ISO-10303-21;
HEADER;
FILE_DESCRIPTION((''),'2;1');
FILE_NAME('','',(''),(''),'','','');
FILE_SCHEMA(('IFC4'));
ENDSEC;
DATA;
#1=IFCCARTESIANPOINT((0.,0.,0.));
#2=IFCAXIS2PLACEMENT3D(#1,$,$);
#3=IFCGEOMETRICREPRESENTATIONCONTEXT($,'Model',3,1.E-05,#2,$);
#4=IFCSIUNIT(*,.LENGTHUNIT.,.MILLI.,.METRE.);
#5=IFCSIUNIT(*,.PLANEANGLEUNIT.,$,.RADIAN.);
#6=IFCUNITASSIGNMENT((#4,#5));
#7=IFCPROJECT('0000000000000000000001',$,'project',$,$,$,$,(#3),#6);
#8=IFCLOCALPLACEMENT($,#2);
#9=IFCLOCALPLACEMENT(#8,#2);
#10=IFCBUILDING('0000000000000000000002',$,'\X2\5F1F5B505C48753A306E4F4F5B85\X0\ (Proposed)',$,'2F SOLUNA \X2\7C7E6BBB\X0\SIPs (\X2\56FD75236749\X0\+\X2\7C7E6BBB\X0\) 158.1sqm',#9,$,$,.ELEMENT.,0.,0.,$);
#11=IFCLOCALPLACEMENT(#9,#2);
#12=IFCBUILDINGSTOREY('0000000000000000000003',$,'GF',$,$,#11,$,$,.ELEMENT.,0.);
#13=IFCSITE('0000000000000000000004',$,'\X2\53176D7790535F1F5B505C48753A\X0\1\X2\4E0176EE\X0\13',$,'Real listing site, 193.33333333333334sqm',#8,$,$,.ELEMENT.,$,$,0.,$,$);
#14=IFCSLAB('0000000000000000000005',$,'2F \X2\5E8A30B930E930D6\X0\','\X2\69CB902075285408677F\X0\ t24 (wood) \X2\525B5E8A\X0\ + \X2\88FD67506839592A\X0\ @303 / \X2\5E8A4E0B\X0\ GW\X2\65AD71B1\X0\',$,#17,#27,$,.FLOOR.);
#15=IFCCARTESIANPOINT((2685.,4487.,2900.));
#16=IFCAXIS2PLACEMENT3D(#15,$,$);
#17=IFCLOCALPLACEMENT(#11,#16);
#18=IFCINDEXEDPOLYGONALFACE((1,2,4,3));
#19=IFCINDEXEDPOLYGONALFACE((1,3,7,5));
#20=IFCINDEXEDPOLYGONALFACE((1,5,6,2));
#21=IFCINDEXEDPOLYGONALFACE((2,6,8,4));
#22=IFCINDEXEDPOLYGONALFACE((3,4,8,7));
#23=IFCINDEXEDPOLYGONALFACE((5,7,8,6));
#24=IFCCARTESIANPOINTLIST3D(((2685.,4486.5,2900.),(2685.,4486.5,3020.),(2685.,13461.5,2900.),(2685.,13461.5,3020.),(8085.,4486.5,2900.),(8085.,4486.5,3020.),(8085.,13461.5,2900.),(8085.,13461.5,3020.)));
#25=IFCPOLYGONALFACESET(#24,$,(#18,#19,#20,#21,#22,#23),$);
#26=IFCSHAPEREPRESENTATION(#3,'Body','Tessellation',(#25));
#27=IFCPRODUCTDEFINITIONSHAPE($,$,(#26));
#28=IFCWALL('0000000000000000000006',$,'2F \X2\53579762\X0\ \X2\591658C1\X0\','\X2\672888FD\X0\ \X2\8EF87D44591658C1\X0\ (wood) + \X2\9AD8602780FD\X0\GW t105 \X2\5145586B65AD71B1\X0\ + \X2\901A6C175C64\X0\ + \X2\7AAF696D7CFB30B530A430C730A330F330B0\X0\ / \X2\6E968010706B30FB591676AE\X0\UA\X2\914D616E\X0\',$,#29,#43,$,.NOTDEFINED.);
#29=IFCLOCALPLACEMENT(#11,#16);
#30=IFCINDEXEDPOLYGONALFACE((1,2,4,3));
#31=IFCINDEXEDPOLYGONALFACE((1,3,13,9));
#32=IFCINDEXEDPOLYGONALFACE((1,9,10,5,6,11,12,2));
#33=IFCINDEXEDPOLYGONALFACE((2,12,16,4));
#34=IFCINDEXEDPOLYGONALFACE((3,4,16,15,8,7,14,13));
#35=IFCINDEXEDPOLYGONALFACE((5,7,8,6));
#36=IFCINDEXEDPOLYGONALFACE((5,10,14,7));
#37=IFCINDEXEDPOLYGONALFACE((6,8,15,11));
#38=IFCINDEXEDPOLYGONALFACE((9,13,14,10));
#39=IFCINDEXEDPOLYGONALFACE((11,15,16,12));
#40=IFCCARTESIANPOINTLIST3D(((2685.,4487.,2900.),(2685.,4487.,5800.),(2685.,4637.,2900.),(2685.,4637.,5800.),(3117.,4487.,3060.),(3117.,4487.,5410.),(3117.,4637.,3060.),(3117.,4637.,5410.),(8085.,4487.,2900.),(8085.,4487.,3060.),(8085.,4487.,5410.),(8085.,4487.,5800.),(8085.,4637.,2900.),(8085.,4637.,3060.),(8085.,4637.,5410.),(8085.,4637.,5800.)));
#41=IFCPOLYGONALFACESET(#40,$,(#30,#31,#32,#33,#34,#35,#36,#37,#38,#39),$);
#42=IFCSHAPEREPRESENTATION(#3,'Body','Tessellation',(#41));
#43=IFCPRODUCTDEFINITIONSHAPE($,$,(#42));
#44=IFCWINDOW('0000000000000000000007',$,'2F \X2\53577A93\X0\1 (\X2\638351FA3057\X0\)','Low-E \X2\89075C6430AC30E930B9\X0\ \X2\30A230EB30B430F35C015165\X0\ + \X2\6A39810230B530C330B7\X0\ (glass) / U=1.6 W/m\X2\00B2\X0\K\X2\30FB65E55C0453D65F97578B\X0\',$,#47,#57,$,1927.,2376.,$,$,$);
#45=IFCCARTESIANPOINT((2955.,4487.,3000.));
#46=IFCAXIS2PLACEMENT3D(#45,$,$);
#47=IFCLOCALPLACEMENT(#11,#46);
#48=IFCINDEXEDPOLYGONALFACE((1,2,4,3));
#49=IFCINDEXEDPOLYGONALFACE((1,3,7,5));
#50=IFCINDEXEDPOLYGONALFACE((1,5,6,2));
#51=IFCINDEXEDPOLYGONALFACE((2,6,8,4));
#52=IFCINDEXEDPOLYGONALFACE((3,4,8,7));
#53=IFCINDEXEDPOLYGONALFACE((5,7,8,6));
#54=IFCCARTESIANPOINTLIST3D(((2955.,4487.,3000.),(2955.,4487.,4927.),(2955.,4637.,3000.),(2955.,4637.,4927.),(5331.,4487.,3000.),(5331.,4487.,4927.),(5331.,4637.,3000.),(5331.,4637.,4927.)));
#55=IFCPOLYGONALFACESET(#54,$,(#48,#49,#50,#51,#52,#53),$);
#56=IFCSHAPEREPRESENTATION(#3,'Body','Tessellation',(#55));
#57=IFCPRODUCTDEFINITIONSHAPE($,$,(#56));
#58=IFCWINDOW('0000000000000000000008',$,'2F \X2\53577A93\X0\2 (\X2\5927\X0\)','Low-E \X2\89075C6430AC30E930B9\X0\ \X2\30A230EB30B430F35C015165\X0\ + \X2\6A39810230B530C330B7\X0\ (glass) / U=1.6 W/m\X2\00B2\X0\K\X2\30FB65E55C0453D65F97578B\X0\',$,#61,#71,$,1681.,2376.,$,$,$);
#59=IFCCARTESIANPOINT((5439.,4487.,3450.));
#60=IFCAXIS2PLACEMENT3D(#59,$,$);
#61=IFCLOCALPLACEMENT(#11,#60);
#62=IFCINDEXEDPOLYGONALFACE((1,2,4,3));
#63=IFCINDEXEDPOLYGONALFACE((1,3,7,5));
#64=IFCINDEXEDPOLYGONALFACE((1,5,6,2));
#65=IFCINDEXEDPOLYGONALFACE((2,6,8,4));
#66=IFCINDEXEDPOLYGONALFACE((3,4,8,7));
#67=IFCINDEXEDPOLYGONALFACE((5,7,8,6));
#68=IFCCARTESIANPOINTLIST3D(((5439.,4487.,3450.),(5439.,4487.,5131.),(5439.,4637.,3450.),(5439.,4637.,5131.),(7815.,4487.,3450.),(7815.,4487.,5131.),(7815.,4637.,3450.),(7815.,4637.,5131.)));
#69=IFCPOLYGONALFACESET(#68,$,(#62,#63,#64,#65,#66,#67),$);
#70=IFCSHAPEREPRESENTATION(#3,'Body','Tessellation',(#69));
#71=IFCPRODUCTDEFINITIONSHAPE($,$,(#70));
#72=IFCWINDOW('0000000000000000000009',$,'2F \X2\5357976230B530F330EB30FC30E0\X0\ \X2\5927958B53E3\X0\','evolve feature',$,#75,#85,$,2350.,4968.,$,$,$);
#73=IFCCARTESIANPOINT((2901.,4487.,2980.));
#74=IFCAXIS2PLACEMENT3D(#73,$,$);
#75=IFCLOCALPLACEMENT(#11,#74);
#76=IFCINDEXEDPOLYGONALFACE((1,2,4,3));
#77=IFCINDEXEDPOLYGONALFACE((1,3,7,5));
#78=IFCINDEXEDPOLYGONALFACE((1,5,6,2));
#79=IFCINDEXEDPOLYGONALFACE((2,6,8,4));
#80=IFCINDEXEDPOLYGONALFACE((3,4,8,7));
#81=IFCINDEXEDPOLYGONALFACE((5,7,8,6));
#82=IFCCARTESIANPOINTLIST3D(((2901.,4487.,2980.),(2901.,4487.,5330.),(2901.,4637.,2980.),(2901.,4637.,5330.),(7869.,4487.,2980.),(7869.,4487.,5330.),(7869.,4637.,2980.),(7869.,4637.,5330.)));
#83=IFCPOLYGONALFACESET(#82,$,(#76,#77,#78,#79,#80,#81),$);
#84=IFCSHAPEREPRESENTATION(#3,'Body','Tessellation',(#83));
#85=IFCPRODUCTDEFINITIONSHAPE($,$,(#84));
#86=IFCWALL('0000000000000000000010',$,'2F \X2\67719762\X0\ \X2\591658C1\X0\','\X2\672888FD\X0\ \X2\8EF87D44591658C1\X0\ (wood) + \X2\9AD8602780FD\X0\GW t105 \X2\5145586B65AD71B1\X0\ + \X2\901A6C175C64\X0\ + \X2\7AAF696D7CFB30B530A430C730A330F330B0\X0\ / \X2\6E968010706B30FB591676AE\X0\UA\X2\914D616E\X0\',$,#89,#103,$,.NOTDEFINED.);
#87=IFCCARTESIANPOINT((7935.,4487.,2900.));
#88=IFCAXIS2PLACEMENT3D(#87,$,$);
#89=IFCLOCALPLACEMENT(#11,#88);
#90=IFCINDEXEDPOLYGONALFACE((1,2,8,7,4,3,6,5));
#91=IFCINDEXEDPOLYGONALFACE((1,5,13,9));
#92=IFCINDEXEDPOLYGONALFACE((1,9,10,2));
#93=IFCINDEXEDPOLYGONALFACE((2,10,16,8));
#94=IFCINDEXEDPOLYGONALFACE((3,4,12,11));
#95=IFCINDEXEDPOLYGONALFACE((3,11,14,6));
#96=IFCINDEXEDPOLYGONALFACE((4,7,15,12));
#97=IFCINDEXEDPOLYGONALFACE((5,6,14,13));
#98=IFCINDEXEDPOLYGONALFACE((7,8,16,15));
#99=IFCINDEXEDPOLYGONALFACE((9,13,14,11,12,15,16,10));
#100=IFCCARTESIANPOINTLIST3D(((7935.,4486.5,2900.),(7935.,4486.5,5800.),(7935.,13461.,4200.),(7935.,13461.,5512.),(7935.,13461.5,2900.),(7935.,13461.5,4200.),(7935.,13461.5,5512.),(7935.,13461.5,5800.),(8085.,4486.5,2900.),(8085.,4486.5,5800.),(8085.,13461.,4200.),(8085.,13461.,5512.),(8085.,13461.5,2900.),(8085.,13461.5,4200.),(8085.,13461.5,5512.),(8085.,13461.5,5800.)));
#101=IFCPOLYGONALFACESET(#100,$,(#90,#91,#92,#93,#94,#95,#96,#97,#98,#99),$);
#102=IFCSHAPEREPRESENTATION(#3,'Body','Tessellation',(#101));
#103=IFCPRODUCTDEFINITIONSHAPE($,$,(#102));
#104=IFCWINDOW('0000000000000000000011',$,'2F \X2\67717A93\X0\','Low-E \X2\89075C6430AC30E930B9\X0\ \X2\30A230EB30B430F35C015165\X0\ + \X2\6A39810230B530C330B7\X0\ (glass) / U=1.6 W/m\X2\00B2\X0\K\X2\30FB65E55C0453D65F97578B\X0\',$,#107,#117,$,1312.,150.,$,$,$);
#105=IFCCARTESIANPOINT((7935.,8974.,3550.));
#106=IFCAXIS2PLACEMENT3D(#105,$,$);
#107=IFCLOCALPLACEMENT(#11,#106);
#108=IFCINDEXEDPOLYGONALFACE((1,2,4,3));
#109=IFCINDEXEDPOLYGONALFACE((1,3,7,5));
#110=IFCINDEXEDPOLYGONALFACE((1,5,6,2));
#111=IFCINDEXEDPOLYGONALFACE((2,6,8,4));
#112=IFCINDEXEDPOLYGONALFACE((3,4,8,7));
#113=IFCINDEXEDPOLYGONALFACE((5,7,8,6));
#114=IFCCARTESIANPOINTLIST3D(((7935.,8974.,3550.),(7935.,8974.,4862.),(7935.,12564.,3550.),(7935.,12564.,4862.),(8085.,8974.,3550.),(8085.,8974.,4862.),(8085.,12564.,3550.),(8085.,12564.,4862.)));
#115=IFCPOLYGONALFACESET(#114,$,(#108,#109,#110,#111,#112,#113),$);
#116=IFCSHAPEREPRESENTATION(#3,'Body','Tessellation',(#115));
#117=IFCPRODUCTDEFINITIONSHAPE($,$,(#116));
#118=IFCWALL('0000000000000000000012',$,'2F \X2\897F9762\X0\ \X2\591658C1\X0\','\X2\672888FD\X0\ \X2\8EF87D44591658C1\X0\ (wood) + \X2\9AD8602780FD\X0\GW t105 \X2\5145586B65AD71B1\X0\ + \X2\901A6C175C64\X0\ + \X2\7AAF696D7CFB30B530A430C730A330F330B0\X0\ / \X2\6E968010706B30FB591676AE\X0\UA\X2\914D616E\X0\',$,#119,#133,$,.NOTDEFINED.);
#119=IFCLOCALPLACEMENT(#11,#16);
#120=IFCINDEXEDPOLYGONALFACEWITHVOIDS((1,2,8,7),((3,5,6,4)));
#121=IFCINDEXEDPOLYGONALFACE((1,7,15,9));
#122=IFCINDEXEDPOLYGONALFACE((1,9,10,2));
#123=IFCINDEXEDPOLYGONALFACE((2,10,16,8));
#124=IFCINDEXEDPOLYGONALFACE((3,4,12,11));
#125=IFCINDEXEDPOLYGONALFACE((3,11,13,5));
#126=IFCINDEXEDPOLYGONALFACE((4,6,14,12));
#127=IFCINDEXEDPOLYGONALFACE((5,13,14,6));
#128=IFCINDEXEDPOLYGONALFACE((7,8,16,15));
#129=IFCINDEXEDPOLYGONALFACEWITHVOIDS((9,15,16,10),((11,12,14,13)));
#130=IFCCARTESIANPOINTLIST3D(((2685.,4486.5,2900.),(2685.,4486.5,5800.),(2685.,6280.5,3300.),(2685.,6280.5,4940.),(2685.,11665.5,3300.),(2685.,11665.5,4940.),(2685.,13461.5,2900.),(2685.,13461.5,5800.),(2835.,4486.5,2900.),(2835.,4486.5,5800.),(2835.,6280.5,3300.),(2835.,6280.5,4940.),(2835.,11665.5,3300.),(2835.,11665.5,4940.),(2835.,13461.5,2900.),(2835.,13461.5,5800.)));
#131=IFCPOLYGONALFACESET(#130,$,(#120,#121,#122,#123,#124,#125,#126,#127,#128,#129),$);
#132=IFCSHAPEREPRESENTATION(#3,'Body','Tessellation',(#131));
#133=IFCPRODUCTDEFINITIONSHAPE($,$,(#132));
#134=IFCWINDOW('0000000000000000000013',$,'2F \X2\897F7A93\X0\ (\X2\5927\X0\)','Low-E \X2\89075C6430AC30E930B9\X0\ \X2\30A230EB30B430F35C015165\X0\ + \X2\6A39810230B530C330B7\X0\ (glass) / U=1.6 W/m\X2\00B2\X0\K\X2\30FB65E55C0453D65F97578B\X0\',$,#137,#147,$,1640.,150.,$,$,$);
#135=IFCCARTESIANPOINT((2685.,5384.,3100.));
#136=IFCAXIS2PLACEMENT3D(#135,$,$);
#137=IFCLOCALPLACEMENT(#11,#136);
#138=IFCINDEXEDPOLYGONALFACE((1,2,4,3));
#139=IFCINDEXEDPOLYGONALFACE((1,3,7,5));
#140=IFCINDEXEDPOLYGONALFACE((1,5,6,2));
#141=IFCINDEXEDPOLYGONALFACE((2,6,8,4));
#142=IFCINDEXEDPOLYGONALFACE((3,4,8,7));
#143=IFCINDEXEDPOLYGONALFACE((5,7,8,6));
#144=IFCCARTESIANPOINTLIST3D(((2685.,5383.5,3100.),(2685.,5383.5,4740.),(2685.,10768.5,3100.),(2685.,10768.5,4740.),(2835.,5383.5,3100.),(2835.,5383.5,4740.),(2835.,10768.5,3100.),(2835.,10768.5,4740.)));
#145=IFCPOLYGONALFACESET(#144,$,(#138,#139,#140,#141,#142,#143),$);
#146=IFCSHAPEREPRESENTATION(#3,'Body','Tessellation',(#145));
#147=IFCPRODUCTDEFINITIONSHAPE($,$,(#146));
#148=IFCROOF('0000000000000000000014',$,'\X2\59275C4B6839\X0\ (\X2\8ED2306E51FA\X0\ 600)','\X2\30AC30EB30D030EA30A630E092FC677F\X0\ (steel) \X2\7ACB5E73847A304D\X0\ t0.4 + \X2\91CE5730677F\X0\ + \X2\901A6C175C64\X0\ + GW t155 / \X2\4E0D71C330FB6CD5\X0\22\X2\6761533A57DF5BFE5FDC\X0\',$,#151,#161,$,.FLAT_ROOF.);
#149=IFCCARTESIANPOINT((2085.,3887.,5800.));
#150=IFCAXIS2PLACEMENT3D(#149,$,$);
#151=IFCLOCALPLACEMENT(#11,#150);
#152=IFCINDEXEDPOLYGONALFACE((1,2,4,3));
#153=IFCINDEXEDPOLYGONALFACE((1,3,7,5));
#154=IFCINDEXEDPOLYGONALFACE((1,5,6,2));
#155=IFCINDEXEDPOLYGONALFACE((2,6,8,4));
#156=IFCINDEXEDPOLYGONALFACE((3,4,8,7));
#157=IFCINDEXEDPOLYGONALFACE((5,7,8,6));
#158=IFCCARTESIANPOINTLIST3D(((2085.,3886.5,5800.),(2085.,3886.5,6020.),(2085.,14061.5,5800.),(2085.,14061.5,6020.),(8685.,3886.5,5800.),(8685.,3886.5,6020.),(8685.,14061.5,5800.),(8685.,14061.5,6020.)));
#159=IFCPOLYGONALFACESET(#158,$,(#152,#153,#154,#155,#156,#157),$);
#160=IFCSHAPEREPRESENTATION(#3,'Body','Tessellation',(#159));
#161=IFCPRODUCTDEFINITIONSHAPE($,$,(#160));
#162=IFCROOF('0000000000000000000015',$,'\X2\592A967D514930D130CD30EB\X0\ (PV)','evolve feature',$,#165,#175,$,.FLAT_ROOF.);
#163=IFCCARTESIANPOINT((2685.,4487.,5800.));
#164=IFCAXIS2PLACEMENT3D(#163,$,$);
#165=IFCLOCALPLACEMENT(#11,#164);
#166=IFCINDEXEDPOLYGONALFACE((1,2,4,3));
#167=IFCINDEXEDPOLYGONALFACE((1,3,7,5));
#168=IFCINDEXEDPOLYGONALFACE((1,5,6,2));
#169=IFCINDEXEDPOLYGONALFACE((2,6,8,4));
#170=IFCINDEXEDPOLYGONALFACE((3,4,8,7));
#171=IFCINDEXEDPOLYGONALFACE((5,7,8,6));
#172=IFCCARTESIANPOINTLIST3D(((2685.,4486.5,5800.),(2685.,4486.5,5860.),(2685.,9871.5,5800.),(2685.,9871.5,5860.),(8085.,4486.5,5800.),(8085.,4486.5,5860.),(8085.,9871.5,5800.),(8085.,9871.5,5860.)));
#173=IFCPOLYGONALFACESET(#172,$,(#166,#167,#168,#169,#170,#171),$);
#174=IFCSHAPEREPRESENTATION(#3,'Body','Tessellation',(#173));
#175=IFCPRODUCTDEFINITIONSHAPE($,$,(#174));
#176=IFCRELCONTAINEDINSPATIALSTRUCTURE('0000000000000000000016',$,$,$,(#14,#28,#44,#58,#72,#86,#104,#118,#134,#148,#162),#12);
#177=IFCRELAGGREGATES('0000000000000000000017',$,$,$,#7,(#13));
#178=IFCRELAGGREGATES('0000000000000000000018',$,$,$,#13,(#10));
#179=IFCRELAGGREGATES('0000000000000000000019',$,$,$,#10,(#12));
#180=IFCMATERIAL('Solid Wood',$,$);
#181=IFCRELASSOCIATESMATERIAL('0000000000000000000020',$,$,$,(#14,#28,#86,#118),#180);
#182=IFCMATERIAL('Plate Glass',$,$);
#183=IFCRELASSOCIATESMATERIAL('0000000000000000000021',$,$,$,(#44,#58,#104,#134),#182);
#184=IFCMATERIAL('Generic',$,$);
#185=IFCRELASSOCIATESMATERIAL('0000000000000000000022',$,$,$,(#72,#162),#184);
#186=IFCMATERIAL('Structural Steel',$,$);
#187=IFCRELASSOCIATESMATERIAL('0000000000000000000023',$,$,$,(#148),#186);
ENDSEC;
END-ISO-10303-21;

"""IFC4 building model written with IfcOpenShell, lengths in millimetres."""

from ifc_helpers import new_model, si_unit, frame, frame_2d, origin, place, context, project, spatial, rectangle, extrude, material, element, fill, save


model = new_model("IFC4")

# Units and contexts
model_context = context("Model", 3, precision=1e-05, world=origin())
ifc_project = project(units=[si_unit("LENGTHUNIT", "METRE", prefix="MILLI"), si_unit("PLANEANGLEUNIT", "RADIAN")], contexts=[model_context])

# Site, building, storey
site_placement = place(None, origin())
site = spatial("IfcSite", under=ifc_project, at=site_placement, Name="北海道弟子屈町1丁目13", ObjectType="Real listing site, 193.33333333333334sqm", CompositionType="ELEMENT", RefElevation=0.0)
building_placement = place(site_placement, origin())
building = spatial("IfcBuilding", under=site, at=building_placement, Name="弟子屈町の住宅 (Proposed)", ObjectType="2F SOLUNA 籾殻SIPs (国産杉+籾殻) 158.1sqm", CompositionType="ELEMENT", ElevationOfRefHeight=0.0, ElevationOfTerrain=0.0)
storey_placement = place(building_placement, origin())
storey = spatial("IfcBuildingStorey", under=building, at=storey_placement, Name="GF", CompositionType="ELEMENT", Elevation=0.0)

# Slab
ifc_material_1 = material(Name="Solid Wood")
slab_placement = place(storey_placement, frame((2685.0, 4487.0, 2900.0)))
element("IfcSlab", 1, at=slab_placement, inside=storey, material=ifc_material_1, Name="2F 床スラブ", Description="構造用合板 t24 (wood) 剛床 + 製材根太 @303 / 床下 GW断熱", PredefinedType="FLOOR", context=model_context, shape_type="SweptSolid", body=[
    extrude(rectangle(XDim=5400.0, YDim=8975.0, at=frame_2d((2700.0, 4487.0))), frame((2685.0, 4487.0, 2900.0)), (0.0, 0.0, 1.0), 120.0),
])

# Wall, openings, windows
wall_1_placement = place(storey_placement, frame((2685.0, 4487.0, 2900.0)))
wall_1 = element("IfcWall", 2, at=wall_1_placement, inside=storey, material=ifc_material_1, Name="2F 南面 外壁", Description="木製 軸組外壁 (wood) + 高性能GW t105 充填断熱 + 通気層 + 窯業系サイディング / 準耐火・外皮UA配慮", PredefinedType="NOTDEFINED", context=model_context, shape_type="SweptSolid", body=[
    extrude(rectangle(XDim=5400.0, YDim=150.0, at=frame_2d((2700.0, 75.0))), frame((2685.0, 4487.0, 2900.0)), (0.0, 0.0, 1.0), 2900.0),
])
opening_1_placement = place(storey_placement, frame((2955.0, 4487.0, 3000.0)))
opening_1 = element("IfcOpeningElement", 3, at=opening_1_placement, cuts=wall_1, PredefinedType="NOTDEFINED", context=model_context, shape_type="SweptSolid", body=[
    extrude(rectangle(XDim=2376.0, YDim=150.0, at=frame_2d((1188.0, 75.0))), frame((2955.0, 4487.0, 3000.0)), (0.0, 0.0, 1.0), 1927.0),
])
opening_2_placement = place(storey_placement, frame((5439.0, 4487.0, 3450.0)))
opening_2 = element("IfcOpeningElement", 4, at=opening_2_placement, cuts=wall_1, PredefinedType="NOTDEFINED", context=model_context, shape_type="SweptSolid", body=[
    extrude(rectangle(XDim=2376.0, YDim=150.0, at=frame_2d((1188.0, 75.0))), frame((5439.0, 4487.0, 3450.0)), (0.0, 0.0, 1.0), 1681.0),
])
opening_3_placement = place(storey_placement, frame((2901.0, 4487.0, 2980.0)))
opening_3 = element("IfcOpeningElement", 5, at=opening_3_placement, cuts=wall_1, PredefinedType="NOTDEFINED", context=model_context, shape_type="SweptSolid", body=[
    extrude(rectangle(XDim=4968.0, YDim=150.0, at=frame_2d((2484.0, 75.0))), frame((2901.0, 4487.0, 2980.0)), (0.0, 0.0, 1.0), 2350.0),
])
ifc_material_2 = material(Name="Plate Glass")
window_1_placement = place(storey_placement, frame((2955.0, 4487.0, 3000.0)))
window_1 = element("IfcWindow", 6, at=window_1_placement, inside=storey, material=ifc_material_2, Name="2F 南窓1 (掃出し)", Description="Low-E 複層ガラス アルゴン封入 + 樹脂サッシ (glass) / U=1.6 W/m²K・日射取得型", OverallHeight=1927.0, OverallWidth=2376.0, context=model_context, shape_type="SweptSolid", body=[
    extrude(rectangle(XDim=2376.0, YDim=150.0, at=frame_2d((1188.0, 75.0))), frame((2955.0, 4487.0, 3000.0)), (0.0, 0.0, 1.0), 1927.0),
])
fill(opening_1, window_1)
window_2_placement = place(storey_placement, frame((5439.0, 4487.0, 3450.0)))
window_2 = element("IfcWindow", 7, at=window_2_placement, inside=storey, material=ifc_material_2, Name="2F 南窓2 (大)", Description="Low-E 複層ガラス アルゴン封入 + 樹脂サッシ (glass) / U=1.6 W/m²K・日射取得型", OverallHeight=1681.0, OverallWidth=2376.0, context=model_context, shape_type="SweptSolid", body=[
    extrude(rectangle(XDim=2376.0, YDim=150.0, at=frame_2d((1188.0, 75.0))), frame((5439.0, 4487.0, 3450.0)), (0.0, 0.0, 1.0), 1681.0),
])
fill(opening_2, window_2)
ifc_material_3 = material(Name="Generic")
window_3_placement = place(storey_placement, frame((2901.0, 4487.0, 2980.0)))
window_3 = element("IfcWindow", 8, at=window_3_placement, inside=storey, material=ifc_material_3, Name="2F 南面サンルーム 大開口", Description="evolve feature", OverallHeight=2350.0, OverallWidth=4968.0, context=model_context, shape_type="SweptSolid", body=[
    extrude(rectangle(XDim=4968.0, YDim=150.0, at=frame_2d((2484.0, 75.0))), frame((2901.0, 4487.0, 2980.0)), (0.0, 0.0, 1.0), 2350.0),
])
fill(opening_3, window_3)

# Walls, openings, windows
wall_2_placement = place(storey_placement, frame((7935.0, 4487.0, 2900.0)))
wall_2 = element("IfcWall", 9, at=wall_2_placement, inside=storey, material=ifc_material_1, Name="2F 東面 外壁", Description="木製 軸組外壁 (wood) + 高性能GW t105 充填断熱 + 通気層 + 窯業系サイディング / 準耐火・外皮UA配慮", PredefinedType="NOTDEFINED", context=model_context, shape_type="SweptSolid", body=[
    extrude(rectangle(XDim=150.0, YDim=8975.0, at=frame_2d((75.0, 4487.0))), frame((7935.0, 4487.0, 2900.0)), (0.0, 0.0, 1.0), 2900.0),
])
opening_4_placement = place(storey_placement, frame((7935.0, 8974.0, 3550.0)))
opening_4 = element("IfcOpeningElement", 10, at=opening_4_placement, cuts=wall_2, PredefinedType="NOTDEFINED", context=model_context, shape_type="SweptSolid", body=[
    extrude(rectangle(XDim=150.0, YDim=3590.0, at=frame_2d((75.0, 1795.0))), frame((7935.0, 8974.0, 3550.0)), (0.0, 0.0, 1.0), 1312.0),
])
window_4_placement = place(storey_placement, frame((7935.0, 8974.0, 3550.0)))
window_4 = element("IfcWindow", 11, at=window_4_placement, inside=storey, material=ifc_material_2, Name="2F 東窓", Description="Low-E 複層ガラス アルゴン封入 + 樹脂サッシ (glass) / U=1.6 W/m²K・日射取得型", OverallHeight=1312.0, OverallWidth=150.0, context=model_context, shape_type="SweptSolid", body=[
    extrude(rectangle(XDim=150.0, YDim=3590.0, at=frame_2d((75.0, 1795.0))), frame((7935.0, 8974.0, 3550.0)), (0.0, 0.0, 1.0), 1312.0),
])
fill(opening_4, window_4)
wall_3_placement = place(storey_placement, frame((2685.0, 4487.0, 2900.0)))
wall_3 = element("IfcWall", 12, at=wall_3_placement, inside=storey, material=ifc_material_1, Name="2F 西面 外壁", Description="木製 軸組外壁 (wood) + 高性能GW t105 充填断熱 + 通気層 + 窯業系サイディング / 準耐火・外皮UA配慮", PredefinedType="NOTDEFINED", context=model_context, shape_type="SweptSolid", body=[
    extrude(rectangle(XDim=150.0, YDim=8975.0, at=frame_2d((75.0, 4487.0))), frame((2685.0, 4487.0, 2900.0)), (0.0, 0.0, 1.0), 2900.0),
])
opening_5_placement = place(storey_placement, frame((2685.0, 5384.0, 3100.0)))
opening_5 = element("IfcOpeningElement", 13, at=opening_5_placement, cuts=wall_3, PredefinedType="NOTDEFINED", context=model_context, shape_type="SweptSolid", body=[
    extrude(rectangle(XDim=150.0, YDim=5385.0, at=frame_2d((75.0, 2692.0))), frame((2685.0, 5384.0, 3100.0)), (0.0, 0.0, 1.0), 1640.0),
])
window_5_placement = place(storey_placement, frame((2685.0, 5384.0, 3100.0)))
window_5 = element("IfcWindow", 14, at=window_5_placement, inside=storey, material=ifc_material_2, Name="2F 西窓 (大)", Description="Low-E 複層ガラス アルゴン封入 + 樹脂サッシ (glass) / U=1.6 W/m²K・日射取得型", OverallHeight=1640.0, OverallWidth=150.0, context=model_context, shape_type="SweptSolid", body=[
    extrude(rectangle(XDim=150.0, YDim=5385.0, at=frame_2d((75.0, 2692.0))), frame((2685.0, 5384.0, 3100.0)), (0.0, 0.0, 1.0), 1640.0),
])
fill(opening_5, window_5)

# Roofs
ifc_material_4 = material(Name="Structural Steel")
roof_1_placement = place(storey_placement, frame((2085.0, 3887.0, 5800.0)))
element("IfcRoof", 15, at=roof_1_placement, inside=storey, material=ifc_material_4, Name="大屋根 (軒の出 600)", Description="ガルバリウム鋼板 (steel) 立平葺き t0.4 + 野地板 + 通気層 + GW t155 / 不燃・法22条区域対応", PredefinedType="FLAT_ROOF", context=model_context, shape_type="SweptSolid", body=[
    extrude(rectangle(XDim=6600.0, YDim=10175.0, at=frame_2d((3300.0, 5087.0))), frame((2085.0, 3887.0, 5800.0)), (0.0, 0.0, 1.0), 220.0),
])
roof_2_placement = place(storey_placement, frame((2685.0, 4487.0, 5800.0)))
element("IfcRoof", 16, at=roof_2_placement, inside=storey, material=ifc_material_3, Name="太陽光パネル (PV)", Description="evolve feature", PredefinedType="FLAT_ROOF", context=model_context, shape_type="SweptSolid", body=[
    extrude(rectangle(XDim=5400.0, YDim=5385.0, at=frame_2d((2700.0, 2692.0))), frame((2685.0, 4487.0, 5800.0)), (0.0, 0.0, 1.0), 60.0),
])

save(model, "model.ifc")
